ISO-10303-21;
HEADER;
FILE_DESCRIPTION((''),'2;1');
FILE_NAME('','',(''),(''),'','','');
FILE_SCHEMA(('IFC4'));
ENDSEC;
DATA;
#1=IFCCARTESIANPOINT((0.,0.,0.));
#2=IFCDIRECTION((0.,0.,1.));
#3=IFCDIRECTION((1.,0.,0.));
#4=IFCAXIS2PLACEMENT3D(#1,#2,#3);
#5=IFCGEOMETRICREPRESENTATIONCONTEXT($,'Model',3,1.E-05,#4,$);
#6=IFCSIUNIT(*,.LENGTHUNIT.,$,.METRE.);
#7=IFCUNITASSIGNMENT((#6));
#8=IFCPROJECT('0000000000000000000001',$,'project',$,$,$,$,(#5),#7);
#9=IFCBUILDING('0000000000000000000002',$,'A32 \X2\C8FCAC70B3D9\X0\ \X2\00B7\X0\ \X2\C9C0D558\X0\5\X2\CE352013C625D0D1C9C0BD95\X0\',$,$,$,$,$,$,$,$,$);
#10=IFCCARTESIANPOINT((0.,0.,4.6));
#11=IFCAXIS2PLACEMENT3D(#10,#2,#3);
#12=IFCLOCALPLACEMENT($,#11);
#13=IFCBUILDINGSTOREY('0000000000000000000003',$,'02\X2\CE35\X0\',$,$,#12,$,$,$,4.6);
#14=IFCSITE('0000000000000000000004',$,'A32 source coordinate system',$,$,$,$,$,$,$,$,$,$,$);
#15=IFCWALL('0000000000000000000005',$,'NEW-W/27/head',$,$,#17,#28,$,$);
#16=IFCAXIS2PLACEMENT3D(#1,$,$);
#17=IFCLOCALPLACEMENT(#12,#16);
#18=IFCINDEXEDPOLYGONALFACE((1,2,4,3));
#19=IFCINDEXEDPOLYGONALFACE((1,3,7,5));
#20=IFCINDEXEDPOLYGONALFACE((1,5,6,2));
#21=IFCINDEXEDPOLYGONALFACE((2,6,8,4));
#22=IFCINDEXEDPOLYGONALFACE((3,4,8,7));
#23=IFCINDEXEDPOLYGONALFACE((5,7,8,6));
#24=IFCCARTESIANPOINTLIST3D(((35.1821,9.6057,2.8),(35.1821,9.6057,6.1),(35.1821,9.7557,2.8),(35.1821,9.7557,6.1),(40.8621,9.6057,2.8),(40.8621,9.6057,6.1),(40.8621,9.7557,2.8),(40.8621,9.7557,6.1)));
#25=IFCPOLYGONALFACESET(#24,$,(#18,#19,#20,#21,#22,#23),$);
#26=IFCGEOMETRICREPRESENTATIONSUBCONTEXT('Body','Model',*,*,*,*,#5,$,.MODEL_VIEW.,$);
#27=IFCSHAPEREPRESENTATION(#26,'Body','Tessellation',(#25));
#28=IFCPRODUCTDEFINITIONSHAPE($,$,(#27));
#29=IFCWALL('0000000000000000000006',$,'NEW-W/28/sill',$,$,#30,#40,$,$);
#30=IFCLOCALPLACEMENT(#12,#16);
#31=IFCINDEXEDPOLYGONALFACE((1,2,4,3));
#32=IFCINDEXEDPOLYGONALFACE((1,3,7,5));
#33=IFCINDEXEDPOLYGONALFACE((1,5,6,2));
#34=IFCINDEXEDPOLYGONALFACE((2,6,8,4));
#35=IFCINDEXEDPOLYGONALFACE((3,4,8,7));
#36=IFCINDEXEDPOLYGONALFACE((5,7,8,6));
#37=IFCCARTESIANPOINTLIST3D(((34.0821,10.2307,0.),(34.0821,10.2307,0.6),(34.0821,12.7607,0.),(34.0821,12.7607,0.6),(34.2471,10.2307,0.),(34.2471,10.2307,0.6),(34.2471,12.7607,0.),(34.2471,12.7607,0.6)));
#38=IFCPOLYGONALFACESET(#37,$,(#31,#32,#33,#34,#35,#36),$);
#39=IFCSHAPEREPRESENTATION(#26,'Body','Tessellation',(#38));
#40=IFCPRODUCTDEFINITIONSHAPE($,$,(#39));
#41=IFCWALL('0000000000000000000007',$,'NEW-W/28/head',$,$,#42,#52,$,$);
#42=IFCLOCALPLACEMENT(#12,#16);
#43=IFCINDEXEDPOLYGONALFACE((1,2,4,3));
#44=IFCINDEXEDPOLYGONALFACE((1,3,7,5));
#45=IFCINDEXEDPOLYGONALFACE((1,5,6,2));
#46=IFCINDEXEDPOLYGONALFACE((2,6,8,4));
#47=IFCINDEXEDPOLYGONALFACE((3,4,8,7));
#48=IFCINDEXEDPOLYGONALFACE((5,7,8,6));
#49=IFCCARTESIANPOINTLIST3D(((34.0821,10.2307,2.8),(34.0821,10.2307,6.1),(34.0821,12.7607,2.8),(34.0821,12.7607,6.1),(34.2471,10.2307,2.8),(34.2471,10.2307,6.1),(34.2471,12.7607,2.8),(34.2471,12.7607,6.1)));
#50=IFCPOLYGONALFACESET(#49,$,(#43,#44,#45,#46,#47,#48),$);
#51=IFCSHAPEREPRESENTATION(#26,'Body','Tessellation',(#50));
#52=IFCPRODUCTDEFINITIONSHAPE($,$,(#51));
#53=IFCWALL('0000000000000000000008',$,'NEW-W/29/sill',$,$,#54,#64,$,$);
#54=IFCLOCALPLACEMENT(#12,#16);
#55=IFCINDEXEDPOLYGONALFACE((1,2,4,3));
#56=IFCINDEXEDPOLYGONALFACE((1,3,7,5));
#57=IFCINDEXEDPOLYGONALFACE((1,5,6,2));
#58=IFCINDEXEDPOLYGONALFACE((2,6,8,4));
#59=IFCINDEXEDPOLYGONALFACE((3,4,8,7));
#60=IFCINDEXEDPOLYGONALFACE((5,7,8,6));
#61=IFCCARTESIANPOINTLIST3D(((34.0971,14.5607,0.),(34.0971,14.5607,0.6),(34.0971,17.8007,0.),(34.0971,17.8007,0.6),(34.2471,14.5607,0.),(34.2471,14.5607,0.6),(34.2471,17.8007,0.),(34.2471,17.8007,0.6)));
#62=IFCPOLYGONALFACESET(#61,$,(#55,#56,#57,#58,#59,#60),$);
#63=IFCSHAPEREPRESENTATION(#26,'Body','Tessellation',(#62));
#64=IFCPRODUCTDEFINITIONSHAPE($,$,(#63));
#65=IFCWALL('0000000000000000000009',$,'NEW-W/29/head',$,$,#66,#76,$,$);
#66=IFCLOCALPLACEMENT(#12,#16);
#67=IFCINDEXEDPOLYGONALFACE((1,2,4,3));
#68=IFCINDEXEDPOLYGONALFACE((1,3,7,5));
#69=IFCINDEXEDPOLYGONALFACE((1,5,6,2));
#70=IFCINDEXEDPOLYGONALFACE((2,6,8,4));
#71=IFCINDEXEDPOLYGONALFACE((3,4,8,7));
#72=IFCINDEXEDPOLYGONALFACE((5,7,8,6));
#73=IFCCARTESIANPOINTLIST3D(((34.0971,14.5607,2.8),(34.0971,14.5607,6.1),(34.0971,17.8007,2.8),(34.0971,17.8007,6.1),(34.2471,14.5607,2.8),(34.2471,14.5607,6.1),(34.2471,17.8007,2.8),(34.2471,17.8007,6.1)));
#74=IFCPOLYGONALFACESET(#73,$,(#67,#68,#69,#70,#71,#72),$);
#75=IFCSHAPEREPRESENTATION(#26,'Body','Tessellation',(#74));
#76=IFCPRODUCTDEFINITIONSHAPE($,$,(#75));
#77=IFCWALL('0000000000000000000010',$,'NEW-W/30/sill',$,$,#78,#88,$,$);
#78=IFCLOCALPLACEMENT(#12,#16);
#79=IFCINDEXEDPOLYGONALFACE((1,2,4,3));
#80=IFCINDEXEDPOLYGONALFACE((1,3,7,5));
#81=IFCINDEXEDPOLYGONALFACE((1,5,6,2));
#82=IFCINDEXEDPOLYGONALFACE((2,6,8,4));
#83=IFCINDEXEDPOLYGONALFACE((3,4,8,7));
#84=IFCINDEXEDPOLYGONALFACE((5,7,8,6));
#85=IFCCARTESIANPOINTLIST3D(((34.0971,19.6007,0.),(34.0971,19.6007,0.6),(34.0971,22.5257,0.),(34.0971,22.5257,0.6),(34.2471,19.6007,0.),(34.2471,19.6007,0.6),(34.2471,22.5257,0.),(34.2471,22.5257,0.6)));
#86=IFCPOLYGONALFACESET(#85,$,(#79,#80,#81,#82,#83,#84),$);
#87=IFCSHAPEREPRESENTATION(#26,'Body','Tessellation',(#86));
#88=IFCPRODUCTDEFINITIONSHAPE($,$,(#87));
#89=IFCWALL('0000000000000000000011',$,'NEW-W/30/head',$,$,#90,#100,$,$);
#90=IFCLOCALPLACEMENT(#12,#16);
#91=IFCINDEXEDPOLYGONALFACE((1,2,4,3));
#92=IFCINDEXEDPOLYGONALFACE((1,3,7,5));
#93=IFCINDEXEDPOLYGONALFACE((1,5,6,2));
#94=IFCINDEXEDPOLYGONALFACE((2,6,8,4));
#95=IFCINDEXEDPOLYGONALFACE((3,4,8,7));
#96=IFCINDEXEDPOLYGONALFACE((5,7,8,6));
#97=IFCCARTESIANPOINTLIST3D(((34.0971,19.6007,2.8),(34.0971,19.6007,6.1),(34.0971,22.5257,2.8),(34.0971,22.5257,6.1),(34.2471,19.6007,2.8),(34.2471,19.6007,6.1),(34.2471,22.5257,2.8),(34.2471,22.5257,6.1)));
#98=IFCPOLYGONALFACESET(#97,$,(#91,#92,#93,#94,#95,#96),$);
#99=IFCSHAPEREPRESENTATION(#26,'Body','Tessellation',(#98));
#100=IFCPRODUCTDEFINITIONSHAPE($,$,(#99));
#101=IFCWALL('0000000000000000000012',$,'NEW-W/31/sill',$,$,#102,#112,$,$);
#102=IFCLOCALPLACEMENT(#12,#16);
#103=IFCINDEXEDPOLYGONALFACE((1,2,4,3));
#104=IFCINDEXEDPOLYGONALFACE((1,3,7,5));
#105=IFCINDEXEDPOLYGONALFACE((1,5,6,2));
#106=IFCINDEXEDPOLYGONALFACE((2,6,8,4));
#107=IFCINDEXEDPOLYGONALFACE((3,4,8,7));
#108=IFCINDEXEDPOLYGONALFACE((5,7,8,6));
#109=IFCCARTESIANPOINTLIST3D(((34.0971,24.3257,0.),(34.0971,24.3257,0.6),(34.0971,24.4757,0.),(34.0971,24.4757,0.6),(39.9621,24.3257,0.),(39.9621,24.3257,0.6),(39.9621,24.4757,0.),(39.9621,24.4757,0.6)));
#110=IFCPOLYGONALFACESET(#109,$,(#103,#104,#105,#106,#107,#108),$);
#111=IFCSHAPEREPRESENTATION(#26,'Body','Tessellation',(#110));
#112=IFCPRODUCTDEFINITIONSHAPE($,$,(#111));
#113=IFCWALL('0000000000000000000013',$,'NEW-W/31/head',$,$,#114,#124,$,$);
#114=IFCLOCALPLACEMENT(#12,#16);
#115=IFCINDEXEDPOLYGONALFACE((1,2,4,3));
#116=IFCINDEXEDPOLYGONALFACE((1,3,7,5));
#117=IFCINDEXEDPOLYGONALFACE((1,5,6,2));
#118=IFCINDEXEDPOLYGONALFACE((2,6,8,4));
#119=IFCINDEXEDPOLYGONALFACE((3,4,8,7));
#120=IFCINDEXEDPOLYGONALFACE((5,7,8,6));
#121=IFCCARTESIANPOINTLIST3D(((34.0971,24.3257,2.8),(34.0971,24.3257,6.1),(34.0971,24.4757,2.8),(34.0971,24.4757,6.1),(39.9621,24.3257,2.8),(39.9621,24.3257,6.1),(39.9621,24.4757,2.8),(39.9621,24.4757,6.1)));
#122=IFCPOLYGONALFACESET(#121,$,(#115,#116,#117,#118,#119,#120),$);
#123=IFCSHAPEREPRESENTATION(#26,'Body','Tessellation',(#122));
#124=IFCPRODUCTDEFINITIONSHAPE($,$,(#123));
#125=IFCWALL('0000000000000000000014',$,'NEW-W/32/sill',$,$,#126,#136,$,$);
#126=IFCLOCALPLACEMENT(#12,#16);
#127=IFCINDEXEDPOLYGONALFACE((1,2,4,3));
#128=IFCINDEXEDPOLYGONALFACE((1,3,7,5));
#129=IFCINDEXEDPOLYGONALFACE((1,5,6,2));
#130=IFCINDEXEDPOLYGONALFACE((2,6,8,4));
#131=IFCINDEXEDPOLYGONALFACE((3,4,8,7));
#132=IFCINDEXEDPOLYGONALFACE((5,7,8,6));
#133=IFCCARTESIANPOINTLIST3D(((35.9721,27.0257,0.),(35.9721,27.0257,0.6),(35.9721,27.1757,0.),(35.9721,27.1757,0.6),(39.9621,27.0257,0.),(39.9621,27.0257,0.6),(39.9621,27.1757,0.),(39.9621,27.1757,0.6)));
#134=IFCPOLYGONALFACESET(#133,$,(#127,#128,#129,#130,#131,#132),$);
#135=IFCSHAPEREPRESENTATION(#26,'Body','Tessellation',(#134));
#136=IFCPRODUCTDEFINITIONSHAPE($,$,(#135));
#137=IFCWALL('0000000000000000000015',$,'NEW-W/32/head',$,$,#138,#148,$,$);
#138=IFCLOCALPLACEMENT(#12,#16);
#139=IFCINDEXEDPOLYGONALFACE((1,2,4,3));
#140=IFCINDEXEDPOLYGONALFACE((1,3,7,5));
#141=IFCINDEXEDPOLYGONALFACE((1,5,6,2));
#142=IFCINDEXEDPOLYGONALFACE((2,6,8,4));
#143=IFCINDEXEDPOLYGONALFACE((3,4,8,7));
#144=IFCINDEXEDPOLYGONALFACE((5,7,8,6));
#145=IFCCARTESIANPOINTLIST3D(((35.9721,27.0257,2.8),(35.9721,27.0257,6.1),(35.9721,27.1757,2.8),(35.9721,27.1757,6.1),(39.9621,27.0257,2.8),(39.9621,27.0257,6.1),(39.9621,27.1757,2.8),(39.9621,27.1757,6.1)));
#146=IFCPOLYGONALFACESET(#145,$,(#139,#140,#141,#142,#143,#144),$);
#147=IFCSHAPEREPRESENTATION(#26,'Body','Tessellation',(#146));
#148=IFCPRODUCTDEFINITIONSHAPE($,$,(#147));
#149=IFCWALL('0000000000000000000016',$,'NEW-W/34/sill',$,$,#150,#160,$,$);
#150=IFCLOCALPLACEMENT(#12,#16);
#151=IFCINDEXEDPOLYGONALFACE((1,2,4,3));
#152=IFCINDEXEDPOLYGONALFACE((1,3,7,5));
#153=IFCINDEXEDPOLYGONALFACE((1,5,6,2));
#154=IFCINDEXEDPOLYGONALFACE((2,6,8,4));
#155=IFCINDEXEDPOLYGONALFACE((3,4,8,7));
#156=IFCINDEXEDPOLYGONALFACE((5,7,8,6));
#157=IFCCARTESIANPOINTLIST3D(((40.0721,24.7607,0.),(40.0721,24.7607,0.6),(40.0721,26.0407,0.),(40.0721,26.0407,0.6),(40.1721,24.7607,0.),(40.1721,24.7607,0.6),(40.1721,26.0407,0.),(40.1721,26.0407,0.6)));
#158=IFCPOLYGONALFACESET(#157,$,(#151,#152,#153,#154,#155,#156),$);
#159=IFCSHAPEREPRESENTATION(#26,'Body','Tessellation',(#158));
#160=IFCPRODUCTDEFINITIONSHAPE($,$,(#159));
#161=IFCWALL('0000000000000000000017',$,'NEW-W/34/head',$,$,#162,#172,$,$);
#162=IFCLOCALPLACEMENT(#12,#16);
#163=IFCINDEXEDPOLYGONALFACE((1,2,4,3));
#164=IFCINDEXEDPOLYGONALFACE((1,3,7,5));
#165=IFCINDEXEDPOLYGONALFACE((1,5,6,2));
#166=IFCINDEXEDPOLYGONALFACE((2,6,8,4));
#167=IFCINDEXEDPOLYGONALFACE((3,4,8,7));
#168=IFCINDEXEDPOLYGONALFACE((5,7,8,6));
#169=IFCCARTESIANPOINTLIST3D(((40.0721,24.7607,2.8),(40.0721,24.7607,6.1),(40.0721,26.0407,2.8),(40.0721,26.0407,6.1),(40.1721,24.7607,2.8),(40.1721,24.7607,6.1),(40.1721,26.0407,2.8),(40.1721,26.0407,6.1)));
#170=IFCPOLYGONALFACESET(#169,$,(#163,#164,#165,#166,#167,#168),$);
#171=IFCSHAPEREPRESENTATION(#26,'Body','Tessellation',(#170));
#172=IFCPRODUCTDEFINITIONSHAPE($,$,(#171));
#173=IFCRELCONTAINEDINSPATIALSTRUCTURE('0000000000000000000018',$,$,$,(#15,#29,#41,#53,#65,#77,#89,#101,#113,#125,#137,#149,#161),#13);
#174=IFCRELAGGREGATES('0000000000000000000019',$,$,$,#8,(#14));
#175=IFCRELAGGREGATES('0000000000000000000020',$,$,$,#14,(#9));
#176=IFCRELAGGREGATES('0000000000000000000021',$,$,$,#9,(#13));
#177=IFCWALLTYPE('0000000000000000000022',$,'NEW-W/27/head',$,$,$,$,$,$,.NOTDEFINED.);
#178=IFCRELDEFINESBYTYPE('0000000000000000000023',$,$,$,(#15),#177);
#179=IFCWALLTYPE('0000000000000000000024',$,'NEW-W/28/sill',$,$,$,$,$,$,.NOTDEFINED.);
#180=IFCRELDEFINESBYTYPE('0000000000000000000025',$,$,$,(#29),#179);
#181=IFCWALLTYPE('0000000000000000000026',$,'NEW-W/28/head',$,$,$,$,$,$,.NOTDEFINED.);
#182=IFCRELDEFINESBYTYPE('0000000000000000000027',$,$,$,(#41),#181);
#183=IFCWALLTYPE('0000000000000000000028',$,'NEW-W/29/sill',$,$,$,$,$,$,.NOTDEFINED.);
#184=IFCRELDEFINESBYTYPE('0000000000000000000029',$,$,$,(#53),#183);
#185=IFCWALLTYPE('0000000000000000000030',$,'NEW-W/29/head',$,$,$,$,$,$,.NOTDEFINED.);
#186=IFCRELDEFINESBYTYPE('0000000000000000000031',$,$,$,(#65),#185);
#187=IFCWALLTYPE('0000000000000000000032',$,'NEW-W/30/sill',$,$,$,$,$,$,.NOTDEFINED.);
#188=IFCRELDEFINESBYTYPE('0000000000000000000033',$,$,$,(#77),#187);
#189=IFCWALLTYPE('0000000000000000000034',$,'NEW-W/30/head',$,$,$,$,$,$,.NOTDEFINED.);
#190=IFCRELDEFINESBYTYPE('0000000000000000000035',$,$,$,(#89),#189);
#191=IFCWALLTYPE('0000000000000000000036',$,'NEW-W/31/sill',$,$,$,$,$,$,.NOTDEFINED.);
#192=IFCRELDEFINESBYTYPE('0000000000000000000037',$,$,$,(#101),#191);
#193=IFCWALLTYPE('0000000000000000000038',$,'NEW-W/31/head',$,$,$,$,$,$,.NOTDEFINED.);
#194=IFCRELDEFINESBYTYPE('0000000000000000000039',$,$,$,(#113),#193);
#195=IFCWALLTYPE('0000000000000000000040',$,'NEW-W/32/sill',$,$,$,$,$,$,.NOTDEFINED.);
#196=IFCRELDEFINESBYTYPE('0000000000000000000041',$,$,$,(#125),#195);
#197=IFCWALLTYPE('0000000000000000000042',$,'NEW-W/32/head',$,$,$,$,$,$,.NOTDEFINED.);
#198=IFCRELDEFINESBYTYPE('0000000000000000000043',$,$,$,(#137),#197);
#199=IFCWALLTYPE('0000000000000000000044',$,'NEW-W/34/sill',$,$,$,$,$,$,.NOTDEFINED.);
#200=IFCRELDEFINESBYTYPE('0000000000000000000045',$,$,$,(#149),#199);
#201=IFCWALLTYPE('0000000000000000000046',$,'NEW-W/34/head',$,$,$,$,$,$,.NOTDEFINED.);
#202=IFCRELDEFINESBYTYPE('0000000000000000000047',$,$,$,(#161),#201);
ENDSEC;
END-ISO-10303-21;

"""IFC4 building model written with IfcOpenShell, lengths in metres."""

from ifc_helpers import new_model, si_unit, frame, origin, origin_with_axes, place, context, subcontext, project, spatial, polyline, outline, extrude, source, transform, mapped, type_object, type_shapes, element, save


model = new_model("IFC4")

# Units and contexts
model_context = context("Model", 3, precision=1e-05, world=origin_with_axes())
body_context = subcontext(model_context, "Body", "Model", "MODEL_VIEW")
ifc_project = project(units=[si_unit("LENGTHUNIT", "METRE")], contexts=[model_context])

# Site, building, storey
site = spatial("IfcSite", under=ifc_project, Name="A32 source coordinate system")
building = spatial("IfcBuilding", under=site, Name="A32 주거동 · 지하5층–옥탑지붕")
storey_placement = place(None, frame((0.0, 0.0, 4.6), z_axis=(0.0, 0.0, 1.0), x_axis=(1.0, 0.0, 0.0)))
storey = spatial("IfcBuildingStorey", under=building, at=storey_placement, Name="02층", Elevation=4.6)

# Walls
wall_type_1 = type_object("IfcWallType", Name="NEW-W/27/head", PredefinedType="NOTDEFINED")
shared_shape_1 = source(origin(), body_context, "Body", "SweptSolid", [
    extrude(outline(polyline([(35.1821, 9.6057), (35.1821, 9.7557), (40.8621, 9.7557), (40.8621, 9.6057), (35.1821, 9.6057)])), frame((0.0, 0.0, 2.8)), (0.0, 0.0, 1.0), 3.3),
])
type_shapes(wall_type_1, [shared_shape_1])
wall_1_placement = place(storey_placement, origin_with_axes())
element("IfcWall", 1, at=wall_1_placement, inside=storey, type_object=wall_type_1, Name="NEW-W/27/head", context=body_context, shape_type="MappedRepresentation", body=[
    mapped(shared_shape_1, transform((0.0, 0.0, 0.0), scale=1.0)),
])
wall_type_2 = type_object("IfcWallType", Name="NEW-W/28/sill", PredefinedType="NOTDEFINED")
shared_shape_2 = source(origin(), body_context, "Body", "SweptSolid", [
    extrude(outline(polyline([(34.0821, 10.2307), (34.0821, 12.7607), (34.2471, 12.7607), (34.2471, 10.2307), (34.0821, 10.2307)])), origin(), (0.0, 0.0, 1.0), 0.6),
])
type_shapes(wall_type_2, [shared_shape_2])
wall_2_placement = place(storey_placement, origin_with_axes())
element("IfcWall", 2, at=wall_2_placement, inside=storey, type_object=wall_type_2, Name="NEW-W/28/sill", context=body_context, shape_type="MappedRepresentation", body=[
    mapped(shared_shape_2, transform((0.0, 0.0, 0.0), scale=1.0)),
])
wall_type_3 = type_object("IfcWallType", Name="NEW-W/28/head", PredefinedType="NOTDEFINED")
shared_shape_3 = source(origin(), body_context, "Body", "SweptSolid", [
    extrude(outline(polyline([(34.0821, 10.2307), (34.0821, 12.7607), (34.2471, 12.7607), (34.2471, 10.2307), (34.0821, 10.2307)])), frame((0.0, 0.0, 2.8)), (0.0, 0.0, 1.0), 3.3),
])
type_shapes(wall_type_3, [shared_shape_3])
wall_3_placement = place(storey_placement, origin_with_axes())
element("IfcWall", 3, at=wall_3_placement, inside=storey, type_object=wall_type_3, Name="NEW-W/28/head", context=body_context, shape_type="MappedRepresentation", body=[
    mapped(shared_shape_3, transform((0.0, 0.0, 0.0), scale=1.0)),
])
wall_type_4 = type_object("IfcWallType", Name="NEW-W/29/sill", PredefinedType="NOTDEFINED")
shared_shape_4 = source(origin(), body_context, "Body", "SweptSolid", [
    extrude(outline(polyline([(34.0971, 14.5607), (34.0971, 17.8007), (34.2471, 17.8007), (34.2471, 14.5607), (34.0971, 14.5607)])), origin(), (0.0, 0.0, 1.0), 0.6),
])
type_shapes(wall_type_4, [shared_shape_4])
wall_4_placement = place(storey_placement, origin_with_axes())
element("IfcWall", 4, at=wall_4_placement, inside=storey, type_object=wall_type_4, Name="NEW-W/29/sill", context=body_context, shape_type="MappedRepresentation", body=[
    mapped(shared_shape_4, transform((0.0, 0.0, 0.0), scale=1.0)),
])
wall_type_5 = type_object("IfcWallType", Name="NEW-W/29/head", PredefinedType="NOTDEFINED")
shared_shape_5 = source(origin(), body_context, "Body", "SweptSolid", [
    extrude(outline(polyline([(34.0971, 14.5607), (34.0971, 17.8007), (34.2471, 17.8007), (34.2471, 14.5607), (34.0971, 14.5607)])), frame((0.0, 0.0, 2.8)), (0.0, 0.0, 1.0), 3.3),
])
type_shapes(wall_type_5, [shared_shape_5])
wall_5_placement = place(storey_placement, origin_with_axes())
element("IfcWall", 5, at=wall_5_placement, inside=storey, type_object=wall_type_5, Name="NEW-W/29/head", context=body_context, shape_type="MappedRepresentation", body=[
    mapped(shared_shape_5, transform((0.0, 0.0, 0.0), scale=1.0)),
])
wall_type_6 = type_object("IfcWallType", Name="NEW-W/30/sill", PredefinedType="NOTDEFINED")
shared_shape_6 = source(origin(), body_context, "Body", "SweptSolid", [
    extrude(outline(polyline([(34.0971, 19.6007), (34.0971, 22.5257), (34.2471, 22.5257), (34.2471, 19.6007), (34.0971, 19.6007)])), origin(), (0.0, 0.0, 1.0), 0.6),
])
type_shapes(wall_type_6, [shared_shape_6])
wall_6_placement = place(storey_placement, origin_with_axes())
element("IfcWall", 6, at=wall_6_placement, inside=storey, type_object=wall_type_6, Name="NEW-W/30/sill", context=body_context, shape_type="MappedRepresentation", body=[
    mapped(shared_shape_6, transform((0.0, 0.0, 0.0), scale=1.0)),
])
wall_type_7 = type_object("IfcWallType", Name="NEW-W/30/head", PredefinedType="NOTDEFINED")
shared_shape_7 = source(origin(), body_context, "Body", "SweptSolid", [
    extrude(outline(polyline([(34.0971, 19.6007), (34.0971, 22.5257), (34.2471, 22.5257), (34.2471, 19.6007), (34.0971, 19.6007)])), frame((0.0, 0.0, 2.8)), (0.0, 0.0, 1.0), 3.3),
])
type_shapes(wall_type_7, [shared_shape_7])
wall_7_placement = place(storey_placement, origin_with_axes())
element("IfcWall", 7, at=wall_7_placement, inside=storey, type_object=wall_type_7, Name="NEW-W/30/head", context=body_context, shape_type="MappedRepresentation", body=[
    mapped(shared_shape_7, transform((0.0, 0.0, 0.0), scale=1.0)),
])
wall_type_8 = type_object("IfcWallType", Name="NEW-W/31/sill", PredefinedType="NOTDEFINED")
shared_shape_8 = source(origin(), body_context, "Body", "SweptSolid", [
    extrude(outline(polyline([(34.0971, 24.3257), (34.0971, 24.4757), (39.9621, 24.4757), (39.9621, 24.3257), (34.0971, 24.3257)])), origin(), (0.0, 0.0, 1.0), 0.6),
])
type_shapes(wall_type_8, [shared_shape_8])
wall_8_placement = place(storey_placement, origin_with_axes())
element("IfcWall", 8, at=wall_8_placement, inside=storey, type_object=wall_type_8, Name="NEW-W/31/sill", context=body_context, shape_type="MappedRepresentation", body=[
    mapped(shared_shape_8, transform((0.0, 0.0, 0.0), scale=1.0)),
])
wall_type_9 = type_object("IfcWallType", Name="NEW-W/31/head", PredefinedType="NOTDEFINED")
shared_shape_9 = source(origin(), body_context, "Body", "SweptSolid", [
    extrude(outline(polyline([(34.0971, 24.3257), (34.0971, 24.4757), (39.9621, 24.4757), (39.9621, 24.3257), (34.0971, 24.3257)])), frame((0.0, 0.0, 2.8)), (0.0, 0.0, 1.0), 3.3),
])
type_shapes(wall_type_9, [shared_shape_9])
wall_9_placement = place(storey_placement, origin_with_axes())
element("IfcWall", 9, at=wall_9_placement, inside=storey, type_object=wall_type_9, Name="NEW-W/31/head", context=body_context, shape_type="MappedRepresentation", body=[
    mapped(shared_shape_9, transform((0.0, 0.0, 0.0), scale=1.0)),
])
wall_type_10 = type_object("IfcWallType", Name="NEW-W/32/sill", PredefinedType="NOTDEFINED")
shared_shape_10 = source(origin(), body_context, "Body", "SweptSolid", [
    extrude(outline(polyline([(35.9721, 27.0257), (35.9721, 27.1757), (39.9621, 27.1757), (39.9621, 27.0257), (35.9721, 27.0257)])), origin(), (0.0, 0.0, 1.0), 0.6),
])
type_shapes(wall_type_10, [shared_shape_10])
wall_10_placement = place(storey_placement, origin_with_axes())
element("IfcWall", 10, at=wall_10_placement, inside=storey, type_object=wall_type_10, Name="NEW-W/32/sill", context=body_context, shape_type="MappedRepresentation", body=[
    mapped(shared_shape_10, transform((0.0, 0.0, 0.0), scale=1.0)),
])
wall_type_11 = type_object("IfcWallType", Name="NEW-W/32/head", PredefinedType="NOTDEFINED")
shared_shape_11 = source(origin(), body_context, "Body", "SweptSolid", [
    extrude(outline(polyline([(35.9721, 27.0257), (35.9721, 27.1757), (39.9621, 27.1757), (39.9621, 27.0257), (35.9721, 27.0257)])), frame((0.0, 0.0, 2.8)), (0.0, 0.0, 1.0), 3.3),
])
type_shapes(wall_type_11, [shared_shape_11])
wall_11_placement = place(storey_placement, origin_with_axes())
element("IfcWall", 11, at=wall_11_placement, inside=storey, type_object=wall_type_11, Name="NEW-W/32/head", context=body_context, shape_type="MappedRepresentation", body=[
    mapped(shared_shape_11, transform((0.0, 0.0, 0.0), scale=1.0)),
])
wall_type_12 = type_object("IfcWallType", Name="NEW-W/34/sill", PredefinedType="NOTDEFINED")
shared_shape_12 = source(origin(), body_context, "Body", "SweptSolid", [
    extrude(outline(polyline([(40.0721, 24.7607), (40.0721, 26.0407), (40.1721, 26.0407), (40.1721, 24.7607), (40.0721, 24.7607)])), origin(), (0.0, 0.0, 1.0), 0.6),
])
type_shapes(wall_type_12, [shared_shape_12])
wall_12_placement = place(storey_placement, origin_with_axes())
element("IfcWall", 12, at=wall_12_placement, inside=storey, type_object=wall_type_12, Name="NEW-W/34/sill", context=body_context, shape_type="MappedRepresentation", body=[
    mapped(shared_shape_12, transform((0.0, 0.0, 0.0), scale=1.0)),
])
wall_type_13 = type_object("IfcWallType", Name="NEW-W/34/head", PredefinedType="NOTDEFINED")
shared_shape_13 = source(origin(), body_context, "Body", "SweptSolid", [
    extrude(outline(polyline([(40.0721, 24.7607), (40.0721, 26.0407), (40.1721, 26.0407), (40.1721, 24.7607), (40.0721, 24.7607)])), frame((0.0, 0.0, 2.8)), (0.0, 0.0, 1.0), 3.3),
])
type_shapes(wall_type_13, [shared_shape_13])
wall_13_placement = place(storey_placement, origin_with_axes())
element("IfcWall", 13, at=wall_13_placement, inside=storey, type_object=wall_type_13, Name="NEW-W/34/head", context=body_context, shape_type="MappedRepresentation", body=[
    mapped(shared_shape_13, transform((0.0, 0.0, 0.0), scale=1.0)),
])

save(model, "model.ifc")
